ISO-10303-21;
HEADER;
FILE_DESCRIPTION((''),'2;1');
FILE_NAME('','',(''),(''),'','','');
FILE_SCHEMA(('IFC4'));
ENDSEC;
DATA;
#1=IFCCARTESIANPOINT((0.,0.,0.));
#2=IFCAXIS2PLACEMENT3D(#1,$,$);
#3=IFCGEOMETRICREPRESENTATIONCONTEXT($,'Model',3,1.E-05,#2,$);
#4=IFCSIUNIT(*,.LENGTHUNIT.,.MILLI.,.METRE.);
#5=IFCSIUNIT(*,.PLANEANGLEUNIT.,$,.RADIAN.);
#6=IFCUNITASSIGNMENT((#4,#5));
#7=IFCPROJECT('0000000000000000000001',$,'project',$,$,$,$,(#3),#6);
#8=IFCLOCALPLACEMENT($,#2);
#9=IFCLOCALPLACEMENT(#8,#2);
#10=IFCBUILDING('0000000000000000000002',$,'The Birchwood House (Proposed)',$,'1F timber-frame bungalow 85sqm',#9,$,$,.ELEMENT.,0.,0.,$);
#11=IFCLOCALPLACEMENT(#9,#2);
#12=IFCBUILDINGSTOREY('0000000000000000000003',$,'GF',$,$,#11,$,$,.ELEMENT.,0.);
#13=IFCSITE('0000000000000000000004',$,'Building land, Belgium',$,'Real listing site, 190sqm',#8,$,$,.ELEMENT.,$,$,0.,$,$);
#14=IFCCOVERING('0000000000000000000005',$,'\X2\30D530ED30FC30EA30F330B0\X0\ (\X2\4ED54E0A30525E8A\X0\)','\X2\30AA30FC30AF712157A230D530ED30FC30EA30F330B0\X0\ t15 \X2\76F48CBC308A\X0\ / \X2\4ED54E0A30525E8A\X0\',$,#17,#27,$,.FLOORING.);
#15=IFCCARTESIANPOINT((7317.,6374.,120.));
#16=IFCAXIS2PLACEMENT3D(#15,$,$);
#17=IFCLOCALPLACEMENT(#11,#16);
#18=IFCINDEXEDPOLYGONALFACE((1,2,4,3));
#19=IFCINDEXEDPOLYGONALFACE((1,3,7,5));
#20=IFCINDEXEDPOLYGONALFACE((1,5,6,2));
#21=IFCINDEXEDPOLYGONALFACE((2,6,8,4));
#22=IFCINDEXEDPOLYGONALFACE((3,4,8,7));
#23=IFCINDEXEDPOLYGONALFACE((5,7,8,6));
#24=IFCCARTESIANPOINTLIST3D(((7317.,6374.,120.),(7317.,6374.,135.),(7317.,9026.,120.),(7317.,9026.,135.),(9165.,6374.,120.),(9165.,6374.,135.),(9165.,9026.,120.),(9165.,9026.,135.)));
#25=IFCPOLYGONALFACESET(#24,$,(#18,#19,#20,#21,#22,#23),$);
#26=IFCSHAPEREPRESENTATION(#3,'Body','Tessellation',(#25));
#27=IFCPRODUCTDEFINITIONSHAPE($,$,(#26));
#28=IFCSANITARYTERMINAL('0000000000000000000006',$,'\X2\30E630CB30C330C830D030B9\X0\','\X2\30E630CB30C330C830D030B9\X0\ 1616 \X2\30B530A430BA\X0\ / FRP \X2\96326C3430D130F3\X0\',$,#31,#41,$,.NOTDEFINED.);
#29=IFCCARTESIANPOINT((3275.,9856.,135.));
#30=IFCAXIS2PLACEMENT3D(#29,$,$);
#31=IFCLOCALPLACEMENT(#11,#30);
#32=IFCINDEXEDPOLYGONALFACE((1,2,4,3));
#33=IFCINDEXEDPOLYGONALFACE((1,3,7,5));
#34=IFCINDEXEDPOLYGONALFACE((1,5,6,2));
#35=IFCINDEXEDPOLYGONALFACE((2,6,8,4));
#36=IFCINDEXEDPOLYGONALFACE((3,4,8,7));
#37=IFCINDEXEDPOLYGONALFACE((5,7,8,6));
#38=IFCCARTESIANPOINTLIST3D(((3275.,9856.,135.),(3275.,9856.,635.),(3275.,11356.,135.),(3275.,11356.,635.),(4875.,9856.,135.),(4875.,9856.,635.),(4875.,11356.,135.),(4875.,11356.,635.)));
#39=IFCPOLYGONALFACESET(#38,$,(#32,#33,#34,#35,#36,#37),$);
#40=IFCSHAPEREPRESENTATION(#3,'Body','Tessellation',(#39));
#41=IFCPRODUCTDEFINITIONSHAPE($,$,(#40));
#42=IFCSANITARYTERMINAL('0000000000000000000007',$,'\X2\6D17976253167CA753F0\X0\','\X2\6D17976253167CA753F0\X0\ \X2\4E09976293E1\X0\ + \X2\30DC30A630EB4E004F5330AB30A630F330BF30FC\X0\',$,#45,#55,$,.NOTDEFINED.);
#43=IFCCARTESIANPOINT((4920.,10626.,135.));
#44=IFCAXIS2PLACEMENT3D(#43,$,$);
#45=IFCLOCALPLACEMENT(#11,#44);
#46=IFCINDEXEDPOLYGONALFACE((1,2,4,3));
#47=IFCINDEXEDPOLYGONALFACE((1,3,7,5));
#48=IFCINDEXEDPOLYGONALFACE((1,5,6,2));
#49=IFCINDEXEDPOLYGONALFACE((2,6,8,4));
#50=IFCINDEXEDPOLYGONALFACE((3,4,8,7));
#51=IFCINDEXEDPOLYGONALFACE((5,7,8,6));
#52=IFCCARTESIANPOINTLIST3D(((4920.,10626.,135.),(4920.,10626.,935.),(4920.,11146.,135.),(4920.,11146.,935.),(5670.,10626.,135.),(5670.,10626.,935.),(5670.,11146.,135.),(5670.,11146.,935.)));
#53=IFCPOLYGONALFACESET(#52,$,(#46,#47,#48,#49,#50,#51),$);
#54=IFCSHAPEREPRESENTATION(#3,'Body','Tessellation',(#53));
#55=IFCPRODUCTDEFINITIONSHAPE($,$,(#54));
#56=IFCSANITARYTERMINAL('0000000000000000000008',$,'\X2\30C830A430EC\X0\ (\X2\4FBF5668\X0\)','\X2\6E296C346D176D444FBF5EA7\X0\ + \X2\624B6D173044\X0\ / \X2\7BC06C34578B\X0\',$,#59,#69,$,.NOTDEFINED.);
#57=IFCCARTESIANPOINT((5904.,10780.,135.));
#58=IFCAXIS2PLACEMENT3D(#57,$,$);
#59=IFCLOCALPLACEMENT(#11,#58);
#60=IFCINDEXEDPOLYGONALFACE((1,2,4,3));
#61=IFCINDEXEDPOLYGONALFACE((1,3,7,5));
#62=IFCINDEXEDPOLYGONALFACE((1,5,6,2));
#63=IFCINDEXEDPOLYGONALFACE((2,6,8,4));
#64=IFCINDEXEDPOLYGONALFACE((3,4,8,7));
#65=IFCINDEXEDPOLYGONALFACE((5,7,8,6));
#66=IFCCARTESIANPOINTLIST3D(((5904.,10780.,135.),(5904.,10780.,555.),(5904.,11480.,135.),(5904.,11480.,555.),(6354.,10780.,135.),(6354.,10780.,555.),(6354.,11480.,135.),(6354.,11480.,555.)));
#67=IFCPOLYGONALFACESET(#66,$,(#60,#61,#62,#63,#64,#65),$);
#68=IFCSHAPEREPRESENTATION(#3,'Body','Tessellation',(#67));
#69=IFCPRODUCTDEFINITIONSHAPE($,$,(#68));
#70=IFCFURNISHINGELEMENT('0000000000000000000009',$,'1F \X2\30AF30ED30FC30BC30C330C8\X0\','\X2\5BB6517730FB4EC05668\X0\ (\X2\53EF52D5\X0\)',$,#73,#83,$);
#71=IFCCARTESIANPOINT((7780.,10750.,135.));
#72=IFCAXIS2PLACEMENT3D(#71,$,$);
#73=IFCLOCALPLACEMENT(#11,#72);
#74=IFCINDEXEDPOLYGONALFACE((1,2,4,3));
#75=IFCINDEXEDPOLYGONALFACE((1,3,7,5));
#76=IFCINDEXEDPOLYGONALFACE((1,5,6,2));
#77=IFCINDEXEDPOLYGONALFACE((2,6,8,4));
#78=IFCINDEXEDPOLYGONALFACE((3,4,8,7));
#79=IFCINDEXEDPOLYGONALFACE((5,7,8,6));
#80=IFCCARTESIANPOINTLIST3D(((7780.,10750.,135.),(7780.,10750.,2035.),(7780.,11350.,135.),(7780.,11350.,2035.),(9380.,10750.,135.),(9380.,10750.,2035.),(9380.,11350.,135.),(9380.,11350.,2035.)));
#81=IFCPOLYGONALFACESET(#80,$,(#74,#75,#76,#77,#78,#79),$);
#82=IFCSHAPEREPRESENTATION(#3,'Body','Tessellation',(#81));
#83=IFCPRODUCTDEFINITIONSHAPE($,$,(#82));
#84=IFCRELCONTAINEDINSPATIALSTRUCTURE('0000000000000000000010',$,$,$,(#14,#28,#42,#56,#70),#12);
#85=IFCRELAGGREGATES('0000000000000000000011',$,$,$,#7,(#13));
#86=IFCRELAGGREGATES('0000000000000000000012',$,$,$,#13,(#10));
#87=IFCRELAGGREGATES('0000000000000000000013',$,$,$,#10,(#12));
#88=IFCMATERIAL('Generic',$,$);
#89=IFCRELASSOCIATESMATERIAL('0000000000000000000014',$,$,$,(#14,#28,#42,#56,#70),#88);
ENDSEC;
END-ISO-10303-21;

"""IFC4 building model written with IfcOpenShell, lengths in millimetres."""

from ifc_helpers import new_model, si_unit, frame, frame_2d, origin, place, context, project, spatial, rectangle, extrude, material, element, save


model = new_model("IFC4")

# Units and contexts
model_context = context("Model", 3, precision=1e-05, world=origin())
ifc_project = project(units=[si_unit("LENGTHUNIT", "METRE", prefix="MILLI"), si_unit("PLANEANGLEUNIT", "RADIAN")], contexts=[model_context])

# Site, building, storey
site_placement = place(None, origin())
site = spatial("IfcSite", under=ifc_project, at=site_placement, Name="Building land, Belgium", ObjectType="Real listing site, 190sqm", CompositionType="ELEMENT", RefElevation=0.0)
building_placement = place(site_placement, origin())
building = spatial("IfcBuilding", under=site, at=building_placement, Name="The Birchwood House (Proposed)", ObjectType="1F timber-frame bungalow 85sqm", CompositionType="ELEMENT", ElevationOfRefHeight=0.0, ElevationOfTerrain=0.0)
storey_placement = place(building_placement, origin())
storey = spatial("IfcBuildingStorey", under=building, at=storey_placement, Name="GF", CompositionType="ELEMENT", Elevation=0.0)

# Covering
ifc_material_1 = material(Name="Generic")
covering_1_placement = place(storey_placement, frame((7317.0, 6374.0, 120.0)))
element("IfcCovering", 1, at=covering_1_placement, inside=storey, material=ifc_material_1, Name="フローリング (仕上げ床)", Description="オーク無垢フローリング t15 直貼り / 仕上げ床", PredefinedType="FLOORING", context=model_context, shape_type="SweptSolid", body=[
    extrude(rectangle(XDim=1848.0, YDim=2652.0, at=frame_2d((924.0, 1326.0))), frame((7317.0, 6374.0, 120.0)), (0.0, 0.0, 1.0), 15.0),
])

# Sanitary terminals
sanitary_terminal_1_placement = place(storey_placement, frame((3275.0, 9856.0, 135.0)))
element("IfcSanitaryTerminal", 2, at=sanitary_terminal_1_placement, inside=storey, material=ifc_material_1, Name="ユニットバス", Description="ユニットバス 1616 サイズ / FRP 防水パン", PredefinedType="NOTDEFINED", context=model_context, shape_type="SweptSolid", body=[
    extrude(rectangle(XDim=1600.0, YDim=1500.0, at=frame_2d((800.0, 750.0))), frame((3275.0, 9856.0, 135.0)), (0.0, 0.0, 1.0), 500.0),
])
sanitary_terminal_2_placement = place(storey_placement, frame((4920.0, 10626.0, 135.0)))
element("IfcSanitaryTerminal", 3, at=sanitary_terminal_2_placement, inside=storey, material=ifc_material_1, Name="洗面化粧台", Description="洗面化粧台 三面鏡 + ボウル一体カウンター", PredefinedType="NOTDEFINED", context=model_context, shape_type="SweptSolid", body=[
    extrude(rectangle(XDim=750.0, YDim=520.0, at=frame_2d((375.0, 260.0))), frame((4920.0, 10626.0, 135.0)), (0.0, 0.0, 1.0), 800.0),
])
sanitary_terminal_3_placement = place(storey_placement, frame((5904.0, 10780.0, 135.0)))
element("IfcSanitaryTerminal", 4, at=sanitary_terminal_3_placement, inside=storey, material=ifc_material_1, Name="トイレ (便器)", Description="温水洗浄便座 + 手洗い / 節水型", PredefinedType="NOTDEFINED", context=model_context, shape_type="SweptSolid", body=[
    extrude(rectangle(XDim=450.0, YDim=700.0, at=frame_2d((225.0, 350.0))), frame((5904.0, 10780.0, 135.0)), (0.0, 0.0, 1.0), 420.0),
])

# Furnishing element
furnishing_placement = place(storey_placement, frame((7780.0, 10750.0, 135.0)))
element("IfcFurnishingElement", 5, at=furnishing_placement, inside=storey, material=ifc_material_1, Name="1F クローゼット", Description="家具・什器 (可動)", context=model_context, shape_type="SweptSolid", body=[
    extrude(rectangle(XDim=1600.0, YDim=600.0, at=frame_2d((800.0, 300.0))), frame((7780.0, 10750.0, 135.0)), (0.0, 0.0, 1.0), 1900.0),
])

save(model, "model.ifc")
